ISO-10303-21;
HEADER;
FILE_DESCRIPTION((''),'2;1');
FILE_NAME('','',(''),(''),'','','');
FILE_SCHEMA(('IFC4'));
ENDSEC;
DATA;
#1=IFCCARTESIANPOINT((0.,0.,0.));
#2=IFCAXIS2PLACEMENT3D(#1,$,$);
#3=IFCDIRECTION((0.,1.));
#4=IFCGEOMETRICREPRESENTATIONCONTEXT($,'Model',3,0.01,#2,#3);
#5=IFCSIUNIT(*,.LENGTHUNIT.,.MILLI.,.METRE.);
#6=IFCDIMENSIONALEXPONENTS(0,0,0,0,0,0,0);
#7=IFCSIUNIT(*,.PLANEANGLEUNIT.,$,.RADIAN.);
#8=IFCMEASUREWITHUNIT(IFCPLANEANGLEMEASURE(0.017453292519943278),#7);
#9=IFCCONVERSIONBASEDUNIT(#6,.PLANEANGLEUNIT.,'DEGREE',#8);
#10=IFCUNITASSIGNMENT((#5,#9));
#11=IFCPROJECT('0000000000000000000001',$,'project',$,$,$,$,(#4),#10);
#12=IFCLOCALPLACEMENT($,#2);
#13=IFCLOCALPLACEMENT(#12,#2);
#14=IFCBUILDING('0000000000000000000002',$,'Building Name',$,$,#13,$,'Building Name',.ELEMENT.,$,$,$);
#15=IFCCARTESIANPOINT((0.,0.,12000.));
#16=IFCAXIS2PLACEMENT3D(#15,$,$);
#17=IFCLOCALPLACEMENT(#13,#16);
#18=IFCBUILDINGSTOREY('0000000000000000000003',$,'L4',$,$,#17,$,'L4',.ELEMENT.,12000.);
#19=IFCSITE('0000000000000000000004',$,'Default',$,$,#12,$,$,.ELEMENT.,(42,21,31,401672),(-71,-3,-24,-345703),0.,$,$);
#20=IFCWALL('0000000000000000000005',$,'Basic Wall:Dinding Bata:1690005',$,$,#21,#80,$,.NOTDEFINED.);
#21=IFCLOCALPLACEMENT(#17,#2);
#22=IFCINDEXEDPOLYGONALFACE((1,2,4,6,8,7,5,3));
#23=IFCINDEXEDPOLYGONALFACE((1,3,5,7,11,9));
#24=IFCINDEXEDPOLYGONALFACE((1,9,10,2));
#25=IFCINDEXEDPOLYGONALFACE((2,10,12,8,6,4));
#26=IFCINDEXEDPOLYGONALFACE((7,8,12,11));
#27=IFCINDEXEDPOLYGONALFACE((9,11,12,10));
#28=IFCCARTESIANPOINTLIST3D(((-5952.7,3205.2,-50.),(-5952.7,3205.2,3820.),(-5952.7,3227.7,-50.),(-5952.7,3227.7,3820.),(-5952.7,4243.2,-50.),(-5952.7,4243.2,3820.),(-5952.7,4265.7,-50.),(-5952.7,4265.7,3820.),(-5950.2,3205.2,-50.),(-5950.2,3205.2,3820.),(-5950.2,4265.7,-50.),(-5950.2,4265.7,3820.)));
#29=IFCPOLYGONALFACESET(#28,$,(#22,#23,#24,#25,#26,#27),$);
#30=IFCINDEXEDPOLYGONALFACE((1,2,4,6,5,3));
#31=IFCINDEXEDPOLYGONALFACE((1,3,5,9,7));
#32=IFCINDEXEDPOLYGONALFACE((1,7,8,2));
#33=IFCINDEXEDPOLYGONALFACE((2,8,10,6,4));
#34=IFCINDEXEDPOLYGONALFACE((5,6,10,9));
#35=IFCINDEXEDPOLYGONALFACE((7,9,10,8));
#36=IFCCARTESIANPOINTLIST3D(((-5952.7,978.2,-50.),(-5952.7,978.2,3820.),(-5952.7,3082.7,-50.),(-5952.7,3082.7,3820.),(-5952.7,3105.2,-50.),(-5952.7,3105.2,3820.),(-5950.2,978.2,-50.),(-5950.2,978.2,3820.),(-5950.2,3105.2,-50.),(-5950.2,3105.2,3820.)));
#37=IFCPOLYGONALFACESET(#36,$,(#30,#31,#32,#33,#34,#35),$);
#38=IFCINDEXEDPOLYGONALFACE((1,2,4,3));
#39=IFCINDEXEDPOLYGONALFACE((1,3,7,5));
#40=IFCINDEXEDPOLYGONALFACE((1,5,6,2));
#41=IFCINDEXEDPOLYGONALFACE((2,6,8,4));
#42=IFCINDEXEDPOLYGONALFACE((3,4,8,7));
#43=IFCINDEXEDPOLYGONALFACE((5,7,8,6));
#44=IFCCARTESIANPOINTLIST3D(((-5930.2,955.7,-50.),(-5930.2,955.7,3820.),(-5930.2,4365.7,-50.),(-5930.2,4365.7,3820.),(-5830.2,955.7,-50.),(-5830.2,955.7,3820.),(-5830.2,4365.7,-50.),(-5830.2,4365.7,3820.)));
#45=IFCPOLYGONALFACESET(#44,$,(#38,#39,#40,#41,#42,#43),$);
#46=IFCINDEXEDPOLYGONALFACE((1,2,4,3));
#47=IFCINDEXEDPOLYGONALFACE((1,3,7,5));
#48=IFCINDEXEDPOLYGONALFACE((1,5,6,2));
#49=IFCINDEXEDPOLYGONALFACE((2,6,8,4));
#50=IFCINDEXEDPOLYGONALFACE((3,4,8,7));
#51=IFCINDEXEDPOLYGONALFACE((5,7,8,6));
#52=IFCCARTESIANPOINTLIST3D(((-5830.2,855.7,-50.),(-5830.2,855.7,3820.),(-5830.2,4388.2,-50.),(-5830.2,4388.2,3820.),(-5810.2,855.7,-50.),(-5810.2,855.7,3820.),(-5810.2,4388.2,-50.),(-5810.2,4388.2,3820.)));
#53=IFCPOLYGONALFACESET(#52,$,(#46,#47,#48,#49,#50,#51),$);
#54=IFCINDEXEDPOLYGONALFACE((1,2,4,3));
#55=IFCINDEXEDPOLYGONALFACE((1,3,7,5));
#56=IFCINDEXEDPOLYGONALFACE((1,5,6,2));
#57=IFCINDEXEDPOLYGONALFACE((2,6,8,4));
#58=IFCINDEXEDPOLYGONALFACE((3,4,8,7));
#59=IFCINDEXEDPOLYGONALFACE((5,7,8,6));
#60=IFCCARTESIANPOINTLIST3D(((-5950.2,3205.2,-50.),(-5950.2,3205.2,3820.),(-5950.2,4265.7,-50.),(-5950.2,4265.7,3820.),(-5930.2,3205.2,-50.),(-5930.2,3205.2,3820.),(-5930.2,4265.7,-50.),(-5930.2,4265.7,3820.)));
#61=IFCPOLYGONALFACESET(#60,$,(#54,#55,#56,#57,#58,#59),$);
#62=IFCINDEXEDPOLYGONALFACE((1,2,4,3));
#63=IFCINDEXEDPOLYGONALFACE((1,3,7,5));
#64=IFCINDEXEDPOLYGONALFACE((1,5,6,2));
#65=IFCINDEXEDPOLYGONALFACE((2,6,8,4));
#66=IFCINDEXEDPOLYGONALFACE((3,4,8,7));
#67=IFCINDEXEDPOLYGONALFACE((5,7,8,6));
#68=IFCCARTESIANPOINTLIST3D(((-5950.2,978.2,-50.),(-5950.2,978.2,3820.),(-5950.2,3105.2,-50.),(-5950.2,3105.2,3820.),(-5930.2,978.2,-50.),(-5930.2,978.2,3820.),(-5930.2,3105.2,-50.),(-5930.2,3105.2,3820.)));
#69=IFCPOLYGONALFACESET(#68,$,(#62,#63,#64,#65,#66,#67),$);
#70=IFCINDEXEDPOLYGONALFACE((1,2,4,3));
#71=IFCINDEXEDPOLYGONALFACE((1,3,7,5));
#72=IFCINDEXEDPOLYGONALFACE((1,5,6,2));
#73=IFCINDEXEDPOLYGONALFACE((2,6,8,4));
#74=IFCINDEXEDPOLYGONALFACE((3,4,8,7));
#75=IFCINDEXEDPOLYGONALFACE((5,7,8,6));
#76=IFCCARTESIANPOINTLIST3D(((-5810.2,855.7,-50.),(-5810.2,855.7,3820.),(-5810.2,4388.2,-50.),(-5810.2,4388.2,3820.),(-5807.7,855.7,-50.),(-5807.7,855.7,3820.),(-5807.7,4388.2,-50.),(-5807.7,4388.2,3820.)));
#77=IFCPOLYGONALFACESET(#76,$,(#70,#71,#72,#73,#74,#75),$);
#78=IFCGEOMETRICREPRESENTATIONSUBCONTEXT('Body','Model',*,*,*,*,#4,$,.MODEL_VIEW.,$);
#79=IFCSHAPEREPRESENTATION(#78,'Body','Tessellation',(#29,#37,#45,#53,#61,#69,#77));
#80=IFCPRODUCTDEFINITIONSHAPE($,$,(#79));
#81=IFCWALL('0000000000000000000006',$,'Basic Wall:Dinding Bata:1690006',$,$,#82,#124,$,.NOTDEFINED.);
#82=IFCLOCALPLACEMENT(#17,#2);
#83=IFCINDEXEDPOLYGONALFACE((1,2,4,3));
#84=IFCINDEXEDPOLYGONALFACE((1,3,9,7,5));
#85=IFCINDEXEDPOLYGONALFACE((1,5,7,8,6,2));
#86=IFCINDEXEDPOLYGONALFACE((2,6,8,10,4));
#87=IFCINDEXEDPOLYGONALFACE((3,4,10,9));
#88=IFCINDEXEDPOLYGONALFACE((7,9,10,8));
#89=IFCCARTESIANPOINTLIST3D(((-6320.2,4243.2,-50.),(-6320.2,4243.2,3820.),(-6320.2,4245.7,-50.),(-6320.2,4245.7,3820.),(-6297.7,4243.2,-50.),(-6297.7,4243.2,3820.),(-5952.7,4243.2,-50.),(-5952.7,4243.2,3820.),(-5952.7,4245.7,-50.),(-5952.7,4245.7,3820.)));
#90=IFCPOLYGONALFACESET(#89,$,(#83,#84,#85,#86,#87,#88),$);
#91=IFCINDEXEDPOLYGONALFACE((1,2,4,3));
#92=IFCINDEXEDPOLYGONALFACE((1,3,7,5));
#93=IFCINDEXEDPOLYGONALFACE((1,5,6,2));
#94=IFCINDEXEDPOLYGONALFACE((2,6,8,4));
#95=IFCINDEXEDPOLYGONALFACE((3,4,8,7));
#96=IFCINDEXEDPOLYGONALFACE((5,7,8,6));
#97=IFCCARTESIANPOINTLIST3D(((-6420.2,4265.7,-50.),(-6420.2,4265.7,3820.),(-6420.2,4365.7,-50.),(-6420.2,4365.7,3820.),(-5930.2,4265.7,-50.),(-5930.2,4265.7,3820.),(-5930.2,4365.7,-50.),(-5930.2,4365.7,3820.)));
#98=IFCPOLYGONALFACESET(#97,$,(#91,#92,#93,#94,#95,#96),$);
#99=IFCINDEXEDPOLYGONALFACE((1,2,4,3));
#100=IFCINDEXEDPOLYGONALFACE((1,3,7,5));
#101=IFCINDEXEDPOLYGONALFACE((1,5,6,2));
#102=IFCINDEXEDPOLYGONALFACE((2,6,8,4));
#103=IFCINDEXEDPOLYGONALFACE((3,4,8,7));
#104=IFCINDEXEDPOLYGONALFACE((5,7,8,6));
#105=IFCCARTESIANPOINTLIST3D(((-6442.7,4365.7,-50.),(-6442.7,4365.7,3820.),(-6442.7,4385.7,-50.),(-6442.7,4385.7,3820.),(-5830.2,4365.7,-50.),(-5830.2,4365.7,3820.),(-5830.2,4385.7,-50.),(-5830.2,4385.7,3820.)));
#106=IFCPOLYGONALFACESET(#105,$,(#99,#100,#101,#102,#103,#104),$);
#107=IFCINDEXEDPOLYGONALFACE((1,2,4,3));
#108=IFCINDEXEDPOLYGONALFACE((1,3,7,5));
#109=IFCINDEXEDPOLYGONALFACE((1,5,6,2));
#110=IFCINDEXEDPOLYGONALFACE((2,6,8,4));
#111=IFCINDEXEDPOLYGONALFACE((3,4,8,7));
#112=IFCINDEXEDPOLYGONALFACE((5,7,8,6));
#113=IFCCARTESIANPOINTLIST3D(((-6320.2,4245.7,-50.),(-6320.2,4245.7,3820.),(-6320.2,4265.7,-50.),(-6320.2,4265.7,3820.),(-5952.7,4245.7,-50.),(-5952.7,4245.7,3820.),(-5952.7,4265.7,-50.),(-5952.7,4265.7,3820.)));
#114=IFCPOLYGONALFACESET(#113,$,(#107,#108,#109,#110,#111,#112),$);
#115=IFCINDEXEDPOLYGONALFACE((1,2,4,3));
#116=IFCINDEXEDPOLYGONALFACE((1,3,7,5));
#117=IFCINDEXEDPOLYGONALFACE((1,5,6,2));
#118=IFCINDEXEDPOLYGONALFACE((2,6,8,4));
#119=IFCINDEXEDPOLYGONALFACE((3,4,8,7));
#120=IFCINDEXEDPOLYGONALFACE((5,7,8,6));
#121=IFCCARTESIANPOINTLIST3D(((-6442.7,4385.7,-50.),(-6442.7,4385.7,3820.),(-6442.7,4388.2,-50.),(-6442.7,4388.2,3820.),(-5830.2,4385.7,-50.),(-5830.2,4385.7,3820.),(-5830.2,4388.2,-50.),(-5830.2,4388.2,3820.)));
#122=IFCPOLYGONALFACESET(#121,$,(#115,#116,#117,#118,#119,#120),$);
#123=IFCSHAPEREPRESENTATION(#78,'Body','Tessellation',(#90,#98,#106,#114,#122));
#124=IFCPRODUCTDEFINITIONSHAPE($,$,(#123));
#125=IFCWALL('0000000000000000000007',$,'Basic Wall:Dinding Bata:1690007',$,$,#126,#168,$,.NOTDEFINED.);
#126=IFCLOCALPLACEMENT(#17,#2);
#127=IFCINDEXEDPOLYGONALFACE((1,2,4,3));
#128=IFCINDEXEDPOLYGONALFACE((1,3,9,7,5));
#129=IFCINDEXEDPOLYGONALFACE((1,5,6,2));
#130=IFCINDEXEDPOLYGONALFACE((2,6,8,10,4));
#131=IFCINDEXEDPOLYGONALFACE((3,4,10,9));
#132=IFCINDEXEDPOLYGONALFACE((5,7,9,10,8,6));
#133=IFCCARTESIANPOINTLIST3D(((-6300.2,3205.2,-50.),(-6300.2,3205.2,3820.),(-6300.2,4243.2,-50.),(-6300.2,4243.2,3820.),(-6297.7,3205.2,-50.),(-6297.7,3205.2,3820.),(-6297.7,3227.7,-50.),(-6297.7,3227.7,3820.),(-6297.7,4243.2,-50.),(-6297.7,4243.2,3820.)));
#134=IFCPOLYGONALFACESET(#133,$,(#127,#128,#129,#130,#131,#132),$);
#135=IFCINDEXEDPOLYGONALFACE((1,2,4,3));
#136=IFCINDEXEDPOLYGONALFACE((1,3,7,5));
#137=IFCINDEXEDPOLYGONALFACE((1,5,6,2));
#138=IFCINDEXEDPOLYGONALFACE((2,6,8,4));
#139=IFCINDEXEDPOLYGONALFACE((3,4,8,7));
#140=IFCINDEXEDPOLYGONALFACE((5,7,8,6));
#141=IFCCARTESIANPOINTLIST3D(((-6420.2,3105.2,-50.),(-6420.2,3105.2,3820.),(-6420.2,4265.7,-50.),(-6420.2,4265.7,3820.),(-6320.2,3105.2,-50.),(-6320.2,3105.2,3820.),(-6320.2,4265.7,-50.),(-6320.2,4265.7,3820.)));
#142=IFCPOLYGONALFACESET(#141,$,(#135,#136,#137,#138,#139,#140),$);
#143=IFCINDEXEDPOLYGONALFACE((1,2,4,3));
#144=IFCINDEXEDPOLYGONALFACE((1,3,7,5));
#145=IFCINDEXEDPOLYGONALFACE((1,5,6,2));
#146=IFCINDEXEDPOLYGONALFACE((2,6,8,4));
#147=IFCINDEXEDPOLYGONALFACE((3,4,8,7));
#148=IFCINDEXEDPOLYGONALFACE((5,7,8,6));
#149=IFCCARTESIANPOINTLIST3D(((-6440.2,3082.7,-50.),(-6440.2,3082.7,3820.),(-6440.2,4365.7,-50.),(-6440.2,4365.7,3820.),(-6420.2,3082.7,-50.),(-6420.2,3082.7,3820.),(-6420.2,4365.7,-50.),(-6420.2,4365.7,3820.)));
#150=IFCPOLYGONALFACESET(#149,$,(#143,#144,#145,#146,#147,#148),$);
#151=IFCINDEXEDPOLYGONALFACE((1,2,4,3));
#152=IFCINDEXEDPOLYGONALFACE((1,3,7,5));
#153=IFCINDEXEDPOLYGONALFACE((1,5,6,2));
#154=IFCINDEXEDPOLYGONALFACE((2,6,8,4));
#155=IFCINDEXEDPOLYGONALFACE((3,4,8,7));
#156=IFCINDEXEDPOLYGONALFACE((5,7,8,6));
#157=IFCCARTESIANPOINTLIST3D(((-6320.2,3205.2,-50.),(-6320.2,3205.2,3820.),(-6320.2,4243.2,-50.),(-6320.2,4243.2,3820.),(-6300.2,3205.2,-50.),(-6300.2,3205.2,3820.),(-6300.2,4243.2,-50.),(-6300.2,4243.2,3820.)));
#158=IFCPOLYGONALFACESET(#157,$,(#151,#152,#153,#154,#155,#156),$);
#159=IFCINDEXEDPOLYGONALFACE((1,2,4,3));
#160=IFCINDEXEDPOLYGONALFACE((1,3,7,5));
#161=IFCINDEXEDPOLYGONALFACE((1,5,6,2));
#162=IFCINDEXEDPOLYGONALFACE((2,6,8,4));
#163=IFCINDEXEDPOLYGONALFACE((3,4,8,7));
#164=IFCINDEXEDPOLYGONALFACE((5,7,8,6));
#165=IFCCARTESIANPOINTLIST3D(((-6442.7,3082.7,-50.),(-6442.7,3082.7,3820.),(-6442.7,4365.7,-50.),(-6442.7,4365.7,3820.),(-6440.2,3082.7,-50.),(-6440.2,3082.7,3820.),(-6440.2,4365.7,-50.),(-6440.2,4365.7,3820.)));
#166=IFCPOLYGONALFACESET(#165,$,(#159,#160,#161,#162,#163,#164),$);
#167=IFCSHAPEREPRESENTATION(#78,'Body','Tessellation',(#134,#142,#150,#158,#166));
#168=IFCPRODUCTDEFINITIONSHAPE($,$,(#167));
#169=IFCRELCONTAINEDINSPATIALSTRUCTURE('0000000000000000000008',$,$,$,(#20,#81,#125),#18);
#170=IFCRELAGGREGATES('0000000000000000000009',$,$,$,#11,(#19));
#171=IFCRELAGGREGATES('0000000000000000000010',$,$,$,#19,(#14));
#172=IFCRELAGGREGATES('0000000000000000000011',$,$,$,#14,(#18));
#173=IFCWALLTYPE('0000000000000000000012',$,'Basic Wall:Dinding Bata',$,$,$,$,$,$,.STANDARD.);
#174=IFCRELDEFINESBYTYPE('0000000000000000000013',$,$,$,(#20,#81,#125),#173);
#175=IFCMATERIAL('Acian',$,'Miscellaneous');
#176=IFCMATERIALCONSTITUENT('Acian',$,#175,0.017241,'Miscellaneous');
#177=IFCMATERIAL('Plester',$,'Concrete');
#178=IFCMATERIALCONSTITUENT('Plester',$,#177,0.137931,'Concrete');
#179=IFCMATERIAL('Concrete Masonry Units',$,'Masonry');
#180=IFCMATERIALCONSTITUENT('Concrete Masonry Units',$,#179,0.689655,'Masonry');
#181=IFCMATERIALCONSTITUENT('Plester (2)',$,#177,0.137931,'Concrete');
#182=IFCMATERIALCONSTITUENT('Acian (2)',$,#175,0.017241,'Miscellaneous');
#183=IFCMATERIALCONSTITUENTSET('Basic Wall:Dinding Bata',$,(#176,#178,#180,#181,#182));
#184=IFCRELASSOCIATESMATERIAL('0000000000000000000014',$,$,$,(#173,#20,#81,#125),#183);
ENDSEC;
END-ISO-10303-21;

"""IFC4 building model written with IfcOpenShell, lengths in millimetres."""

from ifc_helpers import new_model, entity, si_unit, converted_unit, direction, frame, origin, place, context, subcontext, project, spatial, indexed_curve, outline, extrude, material, constituent, constituent_set, type_object, element, save


model = new_model("IFC4")

# Units and contexts
model_context = context("Model", 3, precision=0.01, world=origin(), true_north=direction((0.0, 1.0)))
body_context = subcontext(model_context, "Body", "Model", "MODEL_VIEW")
ifc_project = project(units=[si_unit("LENGTHUNIT", "METRE", prefix="MILLI"), converted_unit("PLANEANGLEUNIT", "DEGREE", entity("IfcPlaneAngleMeasure", 0.017453292519943278), si_unit("PLANEANGLEUNIT", "RADIAN"), dimensions=[0, 0, 0, 0, 0, 0, 0])], contexts=[model_context])

# Site, building, storey
site_placement = place(None, origin())
site = spatial("IfcSite", under=ifc_project, at=site_placement, Name="Default", CompositionType="ELEMENT", RefLatitude=(42, 21, 31, 401672), RefLongitude=(-71, -3, -24, -345703), RefElevation=0.0)
building_placement = place(site_placement, origin())
building = spatial("IfcBuilding", under=site, at=building_placement, Name="Building Name", LongName="Building Name", CompositionType="ELEMENT")
storey_placement = place(building_placement, frame((0.0, 0.0, 12000.0)))
storey = spatial("IfcBuildingStorey", under=building, at=storey_placement, Name="L4", LongName="L4", CompositionType="ELEMENT", Elevation=12000.0)

# Walls
ifc_material_1 = material(Name="Acian", Category="Miscellaneous")
ifc_constituent_1 = constituent(ifc_material_1, Name="Acian", Category="Miscellaneous", fraction=0.017241)
ifc_material_2 = material(Name="Plester", Category="Concrete")
ifc_constituent_2 = constituent(ifc_material_2, Name="Plester", Category="Concrete", fraction=0.137931)
ifc_material_3 = material(Name="Concrete Masonry Units", Category="Masonry")
ifc_constituent_3 = constituent(ifc_material_3, Name="Concrete Masonry Units", Category="Masonry", fraction=0.689655)
ifc_constituent_4 = constituent(ifc_material_2, Name="Plester (2)", Category="Concrete", fraction=0.137931)
ifc_constituent_5 = constituent(ifc_material_1, Name="Acian (2)", Category="Miscellaneous", fraction=0.017241)
ifc_constituent_set = constituent_set(constituents=[ifc_constituent_1, ifc_constituent_2, ifc_constituent_3, ifc_constituent_4, ifc_constituent_5], Name="Basic Wall:Dinding Bata")
wall_type = type_object("IfcWallType", Name="Basic Wall:Dinding Bata", PredefinedType="STANDARD", material=ifc_constituent_set)
wall_1_placement = place(storey_placement, frame((-5880.2, 978.2, -50.0), z_axis=(0.0, 0.0, 1.0), x_axis=(0.0, 1.0, 0.0)))
element("IfcWall", 1, at=wall_1_placement, inside=storey, type_object=wall_type, material=ifc_constituent_set, Name="Basic Wall:Dinding Bata:1690005", PredefinedType="NOTDEFINED", context=body_context, shape_type="SweptSolid", body=[
    extrude(outline(indexed_curve([(-507.7, -0.8), (507.7, -0.8), (530.2, -0.8), (530.2, 1.7), (-530.2, 1.7), (-530.2, -0.8), (-507.7, -0.8)], self_intersect=False)), frame((2757.3, 71.7, 0.0), z_axis=(0.0, 0.0, 1.0), x_axis=(-1.0, 0.0, 0.0)), (0.0, 0.0, 1.0), 3870.0),
    extrude(outline(indexed_curve([(-1271.7, -1.5), (855.3, -1.5), (855.3, 1.0), (832.8, 1.0), (-1271.7, 1.0), (-1271.7, -1.5)], self_intersect=False)), frame((1271.7, 71.5, 0.0)), (0.0, 0.0, 1.0), 3870.0),
    extrude(outline(indexed_curve([(-1705.0, -50.0), (1705.0, -50.0), (1705.0, 50.0), (-1705.0, 50.0), (-1705.0, -50.0)], self_intersect=False)), frame((1682.5, 0.0, 0.0)), (0.0, 0.0, 1.0), 3870.0),
    extrude(outline(indexed_curve([(-1766.2, -10.0), (1766.2, -10.0), (1766.2, 10.0), (-1766.2, 10.0), (-1766.2, -10.0)], self_intersect=False)), frame((1643.7, -60.0, 0.0)), (0.0, 0.0, 1.0), 3870.0),
    extrude(outline(indexed_curve([(-530.2, -10.0), (530.2, -10.0), (530.2, 10.0), (-530.2, 10.0), (-530.2, -10.0)], self_intersect=False)), frame((2757.3, 60.0, 0.0), z_axis=(0.0, 0.0, 1.0), x_axis=(-1.0, 0.0, 0.0)), (0.0, 0.0, 1.0), 3870.0),
    extrude(outline(indexed_curve([(-1063.5, -10.0), (1063.5, -10.0), (1063.5, 10.0), (-1063.5, 10.0), (-1063.5, -10.0)], self_intersect=False)), frame((1063.5, 60.0, 0.0)), (0.0, 0.0, 1.0), 3870.0),
    extrude(outline(indexed_curve([(-1.3, -1766.2), (1.2, -1766.2), (1.3, 1766.2), (-1.2, 1766.2), (-1.3, -1766.2)], self_intersect=False)), frame((1643.7, -71.3, 0.0), z_axis=(0.0, 0.0, 1.0), x_axis=(0.0, 1.0, 0.0)), (0.0, 0.0, 1.0), 3870.0),
])
wall_2_placement = place(storey_placement, frame((-5952.7, 4315.7, -50.0), z_axis=(0.0, 0.0, 1.0), x_axis=(-1.0, 0.0, 0.0)))
element("IfcWall", 2, at=wall_2_placement, inside=storey, type_object=wall_type, material=ifc_constituent_set, Name="Basic Wall:Dinding Bata:1690006", PredefinedType="NOTDEFINED", context=body_context, shape_type="SweptSolid", body=[
    extrude(outline(indexed_curve([(-129.0, -1.0), (216.0, -1.0), (216.0, 1.5), (-151.5, 1.5), (-151.5, -1.0), (-129.0, -1.0)], self_intersect=False)), frame((216.0, 71.5, 0.0), z_axis=(0.0, 0.0, 1.0), x_axis=(-1.0, 0.0, 0.0)), (0.0, 0.0, 1.0), 3870.0),
    extrude(outline(indexed_curve([(-245.0, -50.0), (245.0, -50.0), (245.0, 50.0), (-245.0, 50.0), (-245.0, -50.0)], self_intersect=False)), frame((222.5, 0.0, 0.0)), (0.0, 0.0, 1.0), 3870.0),
    extrude(outline(indexed_curve([(-306.3, -10.0), (306.3, -10.0), (306.3, 10.0), (-306.3, 10.0), (-306.3, -10.0)], self_intersect=False)), frame((183.8, -60.0, 0.0)), (0.0, 0.0, 1.0), 3870.0),
    extrude(outline(indexed_curve([(-183.8, -10.0), (183.8, -10.0), (183.8, 10.0), (-183.8, 10.0), (-183.8, -10.0)], self_intersect=False)), frame((183.8, 60.0, 0.0)), (0.0, 0.0, 1.0), 3870.0),
    extrude(outline(indexed_curve([(-1.3, -306.3), (1.2, -306.3), (1.3, 306.3), (-1.2, 306.3), (-1.3, -306.3)], self_intersect=False)), frame((183.8, -71.3, 0.0), z_axis=(0.0, 0.0, 1.0), x_axis=(0.0, 1.0, 0.0)), (0.0, 0.0, 1.0), 3870.0),
])
wall_3_placement = place(storey_placement, frame((-6370.2, 4243.2, -50.0), z_axis=(0.0, 0.0, 1.0), x_axis=(0.0, -1.0, 0.0)))
element("IfcWall", 3, at=wall_3_placement, inside=storey, type_object=wall_type, material=ifc_constituent_set, Name="Basic Wall:Dinding Bata:1690007", PredefinedType="NOTDEFINED", context=body_context, shape_type="SweptSolid", body=[
    extrude(outline(indexed_curve([(-397.2, -1.0), (618.3, -1.0), (618.3, 1.5), (-419.7, 1.5), (-419.7, -1.0), (-397.2, -1.0)], self_intersect=False)), frame((618.3, 71.5, 0.0), z_axis=(0.0, 0.0, 1.0), x_axis=(-1.0, 0.0, 0.0)), (0.0, 0.0, 1.0), 3870.0),
    extrude(outline(indexed_curve([(-580.2, -50.0), (580.2, -50.0), (580.2, 50.0), (-580.2, 50.0), (-580.2, -50.0)], self_intersect=False)), frame((557.7, 0.0, 0.0)), (0.0, 0.0, 1.0), 3870.0),
    extrude(outline(indexed_curve([(-641.5, -10.0), (641.5, -10.0), (641.5, 10.0), (-641.5, 10.0), (-641.5, -10.0)], self_intersect=False)), frame((519.0, -60.0, 0.0)), (0.0, 0.0, 1.0), 3870.0),
    extrude(outline(indexed_curve([(-519.0, -10.0), (519.0, -10.0), (519.0, 10.0), (-519.0, 10.0), (-519.0, -10.0)], self_intersect=False)), frame((519.0, 60.0, 0.0)), (0.0, 0.0, 1.0), 3870.0),
    extrude(outline(indexed_curve([(-1.3, -641.5), (1.2, -641.5), (1.3, 641.5), (-1.2, 641.5), (-1.3, -641.5)], self_intersect=False)), frame((519.0, -71.3, 0.0), z_axis=(0.0, 0.0, 1.0), x_axis=(0.0, 1.0, 0.0)), (0.0, 0.0, 1.0), 3870.0),
])

save(model, "model.ifc")
